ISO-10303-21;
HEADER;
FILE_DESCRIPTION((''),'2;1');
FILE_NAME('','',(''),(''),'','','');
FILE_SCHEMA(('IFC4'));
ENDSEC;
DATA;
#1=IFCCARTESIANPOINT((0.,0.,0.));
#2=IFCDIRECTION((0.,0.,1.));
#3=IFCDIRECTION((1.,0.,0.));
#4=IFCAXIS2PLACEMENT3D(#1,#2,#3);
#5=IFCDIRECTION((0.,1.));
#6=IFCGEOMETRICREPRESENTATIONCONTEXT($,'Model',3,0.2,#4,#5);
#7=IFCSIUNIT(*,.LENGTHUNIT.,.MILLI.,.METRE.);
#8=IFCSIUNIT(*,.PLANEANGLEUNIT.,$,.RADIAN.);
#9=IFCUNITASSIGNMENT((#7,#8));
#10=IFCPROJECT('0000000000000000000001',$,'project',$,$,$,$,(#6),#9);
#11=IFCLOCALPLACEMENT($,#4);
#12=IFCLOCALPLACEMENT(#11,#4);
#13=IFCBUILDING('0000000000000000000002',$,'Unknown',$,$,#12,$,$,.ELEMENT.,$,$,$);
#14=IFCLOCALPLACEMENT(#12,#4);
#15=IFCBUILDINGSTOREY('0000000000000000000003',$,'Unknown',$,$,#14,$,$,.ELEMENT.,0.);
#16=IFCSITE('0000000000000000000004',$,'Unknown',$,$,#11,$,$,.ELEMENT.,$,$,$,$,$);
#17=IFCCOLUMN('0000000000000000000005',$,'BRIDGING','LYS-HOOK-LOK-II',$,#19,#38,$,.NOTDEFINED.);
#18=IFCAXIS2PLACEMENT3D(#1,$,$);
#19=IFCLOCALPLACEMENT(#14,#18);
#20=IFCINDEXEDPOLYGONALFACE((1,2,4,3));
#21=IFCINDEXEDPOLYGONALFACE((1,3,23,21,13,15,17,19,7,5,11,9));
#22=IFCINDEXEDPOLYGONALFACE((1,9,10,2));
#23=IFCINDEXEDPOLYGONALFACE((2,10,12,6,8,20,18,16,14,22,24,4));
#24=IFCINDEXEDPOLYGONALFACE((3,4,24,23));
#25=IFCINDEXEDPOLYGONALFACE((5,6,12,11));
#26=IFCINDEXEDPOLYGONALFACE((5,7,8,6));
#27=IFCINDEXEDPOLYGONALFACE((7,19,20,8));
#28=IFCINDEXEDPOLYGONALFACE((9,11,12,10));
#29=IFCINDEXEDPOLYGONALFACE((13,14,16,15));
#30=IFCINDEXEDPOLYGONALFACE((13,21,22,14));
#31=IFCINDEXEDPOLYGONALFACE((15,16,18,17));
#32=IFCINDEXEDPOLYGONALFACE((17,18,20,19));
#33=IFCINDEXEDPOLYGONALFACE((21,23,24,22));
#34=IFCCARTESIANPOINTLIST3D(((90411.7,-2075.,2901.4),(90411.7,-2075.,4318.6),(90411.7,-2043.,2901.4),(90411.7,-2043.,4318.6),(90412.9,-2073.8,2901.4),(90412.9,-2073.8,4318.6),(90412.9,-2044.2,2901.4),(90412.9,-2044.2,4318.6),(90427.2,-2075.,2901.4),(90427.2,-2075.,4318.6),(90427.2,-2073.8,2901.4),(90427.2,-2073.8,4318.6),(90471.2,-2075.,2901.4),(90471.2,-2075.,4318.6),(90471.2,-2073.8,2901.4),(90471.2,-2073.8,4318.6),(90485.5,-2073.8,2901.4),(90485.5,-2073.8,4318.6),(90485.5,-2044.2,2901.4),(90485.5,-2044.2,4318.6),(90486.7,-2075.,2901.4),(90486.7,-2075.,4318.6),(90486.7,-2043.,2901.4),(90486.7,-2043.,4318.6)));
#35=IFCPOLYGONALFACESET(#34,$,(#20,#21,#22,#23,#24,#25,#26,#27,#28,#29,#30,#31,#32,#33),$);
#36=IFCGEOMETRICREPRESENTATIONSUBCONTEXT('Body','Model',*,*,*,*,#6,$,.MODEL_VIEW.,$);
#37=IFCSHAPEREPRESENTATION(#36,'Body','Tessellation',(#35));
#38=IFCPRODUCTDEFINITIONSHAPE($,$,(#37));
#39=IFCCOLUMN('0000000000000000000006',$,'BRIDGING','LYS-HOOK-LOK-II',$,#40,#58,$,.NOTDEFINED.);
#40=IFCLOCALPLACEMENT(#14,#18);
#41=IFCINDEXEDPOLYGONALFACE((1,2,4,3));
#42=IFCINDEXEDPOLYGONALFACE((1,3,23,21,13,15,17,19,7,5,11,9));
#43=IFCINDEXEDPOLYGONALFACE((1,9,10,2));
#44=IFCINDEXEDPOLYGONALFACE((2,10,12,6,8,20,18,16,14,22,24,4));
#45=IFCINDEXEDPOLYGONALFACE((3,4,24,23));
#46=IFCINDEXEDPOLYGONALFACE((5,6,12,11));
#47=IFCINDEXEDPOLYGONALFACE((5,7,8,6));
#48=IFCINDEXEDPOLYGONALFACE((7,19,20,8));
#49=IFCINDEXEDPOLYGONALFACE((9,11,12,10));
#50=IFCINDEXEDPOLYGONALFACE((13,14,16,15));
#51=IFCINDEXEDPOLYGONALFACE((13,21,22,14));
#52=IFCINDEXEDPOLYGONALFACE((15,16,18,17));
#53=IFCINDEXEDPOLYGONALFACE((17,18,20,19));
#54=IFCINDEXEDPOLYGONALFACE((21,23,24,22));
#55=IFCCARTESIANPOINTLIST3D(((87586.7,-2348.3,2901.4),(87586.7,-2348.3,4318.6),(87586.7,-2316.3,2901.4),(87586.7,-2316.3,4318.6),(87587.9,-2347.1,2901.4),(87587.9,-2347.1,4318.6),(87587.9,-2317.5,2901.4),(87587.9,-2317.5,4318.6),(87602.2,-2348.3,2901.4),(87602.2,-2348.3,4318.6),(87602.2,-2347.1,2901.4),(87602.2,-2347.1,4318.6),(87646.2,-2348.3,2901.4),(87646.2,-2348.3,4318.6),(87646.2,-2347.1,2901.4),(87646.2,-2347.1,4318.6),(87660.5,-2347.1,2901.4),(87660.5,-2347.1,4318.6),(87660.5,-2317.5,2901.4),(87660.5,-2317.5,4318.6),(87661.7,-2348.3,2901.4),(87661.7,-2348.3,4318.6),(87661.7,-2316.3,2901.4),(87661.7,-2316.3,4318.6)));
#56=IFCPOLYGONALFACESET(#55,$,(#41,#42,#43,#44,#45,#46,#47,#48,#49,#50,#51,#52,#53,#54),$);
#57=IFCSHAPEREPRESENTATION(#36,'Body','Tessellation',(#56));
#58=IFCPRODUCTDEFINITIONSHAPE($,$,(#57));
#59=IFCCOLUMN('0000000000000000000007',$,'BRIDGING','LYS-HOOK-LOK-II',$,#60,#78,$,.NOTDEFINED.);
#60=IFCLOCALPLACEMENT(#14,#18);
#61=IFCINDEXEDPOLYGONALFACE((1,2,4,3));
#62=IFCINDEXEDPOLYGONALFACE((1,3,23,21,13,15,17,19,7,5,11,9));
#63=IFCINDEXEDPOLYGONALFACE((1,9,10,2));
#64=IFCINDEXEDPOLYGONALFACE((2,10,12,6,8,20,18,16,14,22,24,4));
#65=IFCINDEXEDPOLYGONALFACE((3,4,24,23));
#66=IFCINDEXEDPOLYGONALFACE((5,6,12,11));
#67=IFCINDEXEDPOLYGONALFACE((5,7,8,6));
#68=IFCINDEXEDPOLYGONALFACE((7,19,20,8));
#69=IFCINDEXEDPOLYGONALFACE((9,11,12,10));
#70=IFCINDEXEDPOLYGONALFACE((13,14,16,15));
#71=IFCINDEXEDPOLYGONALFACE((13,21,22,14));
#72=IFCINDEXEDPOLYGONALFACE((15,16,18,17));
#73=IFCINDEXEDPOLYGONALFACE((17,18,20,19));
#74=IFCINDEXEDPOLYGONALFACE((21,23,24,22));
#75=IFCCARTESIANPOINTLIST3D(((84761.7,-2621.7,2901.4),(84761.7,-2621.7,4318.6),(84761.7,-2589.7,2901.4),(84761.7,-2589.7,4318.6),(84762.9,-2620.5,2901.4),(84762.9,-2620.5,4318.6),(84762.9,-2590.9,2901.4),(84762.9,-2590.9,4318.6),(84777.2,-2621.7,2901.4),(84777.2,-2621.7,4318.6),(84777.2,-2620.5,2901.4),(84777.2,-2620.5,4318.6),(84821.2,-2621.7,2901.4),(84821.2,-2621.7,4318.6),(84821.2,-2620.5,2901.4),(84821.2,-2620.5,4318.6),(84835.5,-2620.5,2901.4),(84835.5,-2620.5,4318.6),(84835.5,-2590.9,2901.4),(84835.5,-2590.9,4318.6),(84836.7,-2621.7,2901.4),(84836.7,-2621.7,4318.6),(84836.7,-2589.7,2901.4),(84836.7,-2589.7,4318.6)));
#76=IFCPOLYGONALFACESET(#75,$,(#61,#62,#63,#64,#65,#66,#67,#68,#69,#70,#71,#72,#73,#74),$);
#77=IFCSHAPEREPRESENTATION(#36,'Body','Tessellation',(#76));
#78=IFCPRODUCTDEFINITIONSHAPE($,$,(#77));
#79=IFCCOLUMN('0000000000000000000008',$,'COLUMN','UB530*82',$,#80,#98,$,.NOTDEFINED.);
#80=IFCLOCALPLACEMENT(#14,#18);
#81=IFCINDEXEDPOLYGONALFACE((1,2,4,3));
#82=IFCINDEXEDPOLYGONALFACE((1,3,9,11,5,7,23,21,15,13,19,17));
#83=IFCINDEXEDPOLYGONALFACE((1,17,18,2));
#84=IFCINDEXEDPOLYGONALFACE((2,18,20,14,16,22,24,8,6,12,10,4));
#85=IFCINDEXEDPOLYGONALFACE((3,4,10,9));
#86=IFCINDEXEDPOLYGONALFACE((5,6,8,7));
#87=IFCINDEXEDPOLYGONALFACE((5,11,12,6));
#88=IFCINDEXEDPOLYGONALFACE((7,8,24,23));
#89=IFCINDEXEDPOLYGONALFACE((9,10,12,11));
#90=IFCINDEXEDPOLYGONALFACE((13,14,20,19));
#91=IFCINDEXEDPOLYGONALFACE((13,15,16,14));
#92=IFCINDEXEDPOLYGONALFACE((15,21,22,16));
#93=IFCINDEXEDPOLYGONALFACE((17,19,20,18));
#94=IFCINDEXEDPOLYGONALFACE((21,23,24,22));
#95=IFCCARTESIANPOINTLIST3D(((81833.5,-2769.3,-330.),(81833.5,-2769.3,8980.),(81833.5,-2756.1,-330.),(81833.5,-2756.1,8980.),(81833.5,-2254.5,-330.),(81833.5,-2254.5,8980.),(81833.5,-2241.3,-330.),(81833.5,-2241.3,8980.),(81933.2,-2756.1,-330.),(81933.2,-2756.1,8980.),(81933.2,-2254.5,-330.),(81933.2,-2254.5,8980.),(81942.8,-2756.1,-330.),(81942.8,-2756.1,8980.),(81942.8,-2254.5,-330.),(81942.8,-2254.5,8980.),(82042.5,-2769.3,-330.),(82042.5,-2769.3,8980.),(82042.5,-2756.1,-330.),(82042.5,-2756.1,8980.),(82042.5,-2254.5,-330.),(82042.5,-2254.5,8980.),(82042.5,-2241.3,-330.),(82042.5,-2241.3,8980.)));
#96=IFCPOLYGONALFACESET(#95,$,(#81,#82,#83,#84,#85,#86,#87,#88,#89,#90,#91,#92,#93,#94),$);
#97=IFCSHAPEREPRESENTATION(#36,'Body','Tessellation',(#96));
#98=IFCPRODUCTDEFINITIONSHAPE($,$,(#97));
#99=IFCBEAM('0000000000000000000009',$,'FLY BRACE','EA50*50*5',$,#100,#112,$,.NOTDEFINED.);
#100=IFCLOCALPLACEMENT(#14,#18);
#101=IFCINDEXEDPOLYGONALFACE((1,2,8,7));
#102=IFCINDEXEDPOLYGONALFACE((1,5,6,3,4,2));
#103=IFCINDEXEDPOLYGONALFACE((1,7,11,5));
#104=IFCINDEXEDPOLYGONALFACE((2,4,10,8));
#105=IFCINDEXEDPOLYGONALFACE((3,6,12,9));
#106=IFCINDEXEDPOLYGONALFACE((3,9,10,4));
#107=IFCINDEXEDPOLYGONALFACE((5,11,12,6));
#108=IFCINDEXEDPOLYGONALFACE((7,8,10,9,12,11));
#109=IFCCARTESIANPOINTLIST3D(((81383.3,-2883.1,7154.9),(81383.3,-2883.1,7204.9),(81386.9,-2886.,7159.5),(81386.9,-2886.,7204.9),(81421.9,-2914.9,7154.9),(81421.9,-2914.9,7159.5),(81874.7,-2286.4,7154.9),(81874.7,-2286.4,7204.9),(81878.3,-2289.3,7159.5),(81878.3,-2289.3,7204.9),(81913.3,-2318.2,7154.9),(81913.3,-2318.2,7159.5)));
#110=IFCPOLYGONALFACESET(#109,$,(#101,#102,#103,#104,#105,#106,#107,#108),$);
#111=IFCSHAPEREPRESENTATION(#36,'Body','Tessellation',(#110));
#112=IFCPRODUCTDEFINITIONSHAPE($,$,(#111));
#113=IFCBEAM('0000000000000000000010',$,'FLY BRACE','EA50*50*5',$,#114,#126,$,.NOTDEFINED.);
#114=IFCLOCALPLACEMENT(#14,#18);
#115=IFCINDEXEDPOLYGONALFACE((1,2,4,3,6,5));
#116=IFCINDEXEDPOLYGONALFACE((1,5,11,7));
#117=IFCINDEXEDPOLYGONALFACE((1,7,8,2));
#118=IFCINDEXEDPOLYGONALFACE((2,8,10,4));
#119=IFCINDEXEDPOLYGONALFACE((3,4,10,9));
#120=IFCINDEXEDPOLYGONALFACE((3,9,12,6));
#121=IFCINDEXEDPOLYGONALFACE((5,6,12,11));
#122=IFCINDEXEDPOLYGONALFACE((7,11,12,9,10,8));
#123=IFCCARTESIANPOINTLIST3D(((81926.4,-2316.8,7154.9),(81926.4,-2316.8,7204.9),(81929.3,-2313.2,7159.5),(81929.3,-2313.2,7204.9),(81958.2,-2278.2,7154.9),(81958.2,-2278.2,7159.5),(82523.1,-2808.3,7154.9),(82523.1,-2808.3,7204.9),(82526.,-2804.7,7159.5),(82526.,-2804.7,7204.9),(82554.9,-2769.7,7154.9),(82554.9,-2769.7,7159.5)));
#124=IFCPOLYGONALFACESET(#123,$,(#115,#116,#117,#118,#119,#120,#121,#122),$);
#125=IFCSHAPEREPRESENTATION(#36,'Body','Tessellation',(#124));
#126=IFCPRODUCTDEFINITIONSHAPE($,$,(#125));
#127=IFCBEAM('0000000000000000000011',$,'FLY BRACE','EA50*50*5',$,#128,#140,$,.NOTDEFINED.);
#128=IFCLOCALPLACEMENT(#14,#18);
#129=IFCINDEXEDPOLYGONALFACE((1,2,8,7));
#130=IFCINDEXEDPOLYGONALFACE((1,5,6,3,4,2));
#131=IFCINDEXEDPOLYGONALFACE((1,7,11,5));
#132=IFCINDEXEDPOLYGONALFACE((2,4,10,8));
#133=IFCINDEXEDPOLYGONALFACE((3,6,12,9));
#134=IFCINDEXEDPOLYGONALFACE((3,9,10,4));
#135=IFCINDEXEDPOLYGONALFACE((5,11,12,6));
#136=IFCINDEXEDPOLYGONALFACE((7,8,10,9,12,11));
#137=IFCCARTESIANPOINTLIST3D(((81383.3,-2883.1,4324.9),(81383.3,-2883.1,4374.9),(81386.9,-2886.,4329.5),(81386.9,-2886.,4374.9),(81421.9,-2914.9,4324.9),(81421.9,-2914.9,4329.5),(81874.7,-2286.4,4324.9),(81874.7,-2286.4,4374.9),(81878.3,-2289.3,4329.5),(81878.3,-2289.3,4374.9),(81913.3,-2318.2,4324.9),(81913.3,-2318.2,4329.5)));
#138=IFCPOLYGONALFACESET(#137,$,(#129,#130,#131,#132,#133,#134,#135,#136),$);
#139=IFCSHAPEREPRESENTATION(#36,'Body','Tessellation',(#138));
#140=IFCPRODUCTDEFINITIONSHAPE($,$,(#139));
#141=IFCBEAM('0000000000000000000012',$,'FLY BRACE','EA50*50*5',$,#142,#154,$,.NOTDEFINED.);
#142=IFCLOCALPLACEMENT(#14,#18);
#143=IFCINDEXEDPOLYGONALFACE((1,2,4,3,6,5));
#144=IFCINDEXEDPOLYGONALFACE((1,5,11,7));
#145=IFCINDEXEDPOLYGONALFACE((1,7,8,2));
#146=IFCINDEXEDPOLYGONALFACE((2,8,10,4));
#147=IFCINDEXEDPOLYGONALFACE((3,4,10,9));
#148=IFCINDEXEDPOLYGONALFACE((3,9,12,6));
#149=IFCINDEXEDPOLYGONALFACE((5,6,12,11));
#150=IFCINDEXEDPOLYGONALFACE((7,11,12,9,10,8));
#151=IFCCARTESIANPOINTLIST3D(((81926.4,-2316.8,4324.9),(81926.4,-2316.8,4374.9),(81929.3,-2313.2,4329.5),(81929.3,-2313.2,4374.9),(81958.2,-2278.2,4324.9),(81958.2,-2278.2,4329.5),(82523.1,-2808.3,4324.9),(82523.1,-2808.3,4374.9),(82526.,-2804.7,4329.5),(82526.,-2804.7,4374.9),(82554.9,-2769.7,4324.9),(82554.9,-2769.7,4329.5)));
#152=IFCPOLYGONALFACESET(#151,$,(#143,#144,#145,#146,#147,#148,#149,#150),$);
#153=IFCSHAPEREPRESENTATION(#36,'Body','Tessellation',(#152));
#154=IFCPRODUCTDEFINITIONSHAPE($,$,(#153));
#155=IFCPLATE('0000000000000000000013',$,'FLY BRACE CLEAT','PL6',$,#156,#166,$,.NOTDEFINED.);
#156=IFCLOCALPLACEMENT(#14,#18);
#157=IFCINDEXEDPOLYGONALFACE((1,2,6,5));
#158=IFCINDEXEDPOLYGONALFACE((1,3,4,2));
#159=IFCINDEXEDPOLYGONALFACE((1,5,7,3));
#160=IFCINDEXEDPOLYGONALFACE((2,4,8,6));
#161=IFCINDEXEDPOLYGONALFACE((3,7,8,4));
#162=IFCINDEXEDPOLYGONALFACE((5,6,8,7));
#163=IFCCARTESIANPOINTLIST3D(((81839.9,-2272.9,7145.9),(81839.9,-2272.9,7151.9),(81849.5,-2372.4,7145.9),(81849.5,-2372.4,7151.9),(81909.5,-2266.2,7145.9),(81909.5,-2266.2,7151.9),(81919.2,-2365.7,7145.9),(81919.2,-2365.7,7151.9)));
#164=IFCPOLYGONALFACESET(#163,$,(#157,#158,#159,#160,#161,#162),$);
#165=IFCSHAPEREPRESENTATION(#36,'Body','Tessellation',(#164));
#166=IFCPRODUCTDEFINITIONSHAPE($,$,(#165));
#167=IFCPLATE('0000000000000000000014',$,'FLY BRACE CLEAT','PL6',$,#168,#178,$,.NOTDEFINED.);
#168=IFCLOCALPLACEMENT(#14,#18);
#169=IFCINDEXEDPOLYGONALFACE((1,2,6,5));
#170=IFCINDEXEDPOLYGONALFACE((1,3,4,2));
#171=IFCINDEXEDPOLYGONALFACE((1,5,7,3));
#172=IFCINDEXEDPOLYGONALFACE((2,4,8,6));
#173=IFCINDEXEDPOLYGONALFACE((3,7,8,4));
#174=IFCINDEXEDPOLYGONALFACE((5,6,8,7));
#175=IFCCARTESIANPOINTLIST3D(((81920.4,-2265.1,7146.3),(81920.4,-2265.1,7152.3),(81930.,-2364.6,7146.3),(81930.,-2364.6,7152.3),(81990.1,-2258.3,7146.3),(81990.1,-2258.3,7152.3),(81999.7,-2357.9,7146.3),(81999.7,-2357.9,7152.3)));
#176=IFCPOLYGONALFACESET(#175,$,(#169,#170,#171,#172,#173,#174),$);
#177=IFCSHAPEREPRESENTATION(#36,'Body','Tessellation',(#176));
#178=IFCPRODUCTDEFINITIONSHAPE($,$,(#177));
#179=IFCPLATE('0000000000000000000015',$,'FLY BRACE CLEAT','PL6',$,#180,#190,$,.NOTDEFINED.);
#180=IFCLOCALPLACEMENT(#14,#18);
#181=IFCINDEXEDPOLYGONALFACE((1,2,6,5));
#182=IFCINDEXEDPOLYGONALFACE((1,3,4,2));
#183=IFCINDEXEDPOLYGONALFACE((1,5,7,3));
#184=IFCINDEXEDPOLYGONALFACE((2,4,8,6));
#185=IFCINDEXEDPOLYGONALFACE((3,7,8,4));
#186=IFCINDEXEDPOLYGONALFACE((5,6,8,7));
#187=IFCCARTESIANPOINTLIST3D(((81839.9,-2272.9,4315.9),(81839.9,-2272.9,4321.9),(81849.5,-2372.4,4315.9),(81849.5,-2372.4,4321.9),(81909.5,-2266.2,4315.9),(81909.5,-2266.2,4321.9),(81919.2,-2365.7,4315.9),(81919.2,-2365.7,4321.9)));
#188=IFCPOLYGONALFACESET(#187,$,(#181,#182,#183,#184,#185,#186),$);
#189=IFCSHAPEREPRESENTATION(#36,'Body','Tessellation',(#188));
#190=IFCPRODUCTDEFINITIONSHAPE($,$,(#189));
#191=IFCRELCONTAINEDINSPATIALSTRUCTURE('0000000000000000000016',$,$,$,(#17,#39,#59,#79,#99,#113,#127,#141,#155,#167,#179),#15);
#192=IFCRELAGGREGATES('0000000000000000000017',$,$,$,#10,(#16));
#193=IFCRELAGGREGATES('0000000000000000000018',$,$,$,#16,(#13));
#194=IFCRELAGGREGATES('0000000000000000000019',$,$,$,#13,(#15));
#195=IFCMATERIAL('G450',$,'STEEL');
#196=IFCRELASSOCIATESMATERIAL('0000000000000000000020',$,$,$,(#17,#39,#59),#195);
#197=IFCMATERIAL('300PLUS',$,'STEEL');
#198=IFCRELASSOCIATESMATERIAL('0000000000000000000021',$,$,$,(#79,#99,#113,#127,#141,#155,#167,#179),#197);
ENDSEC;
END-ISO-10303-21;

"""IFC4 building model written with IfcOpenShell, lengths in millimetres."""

from ifc_helpers import new_model, si_unit, direction, frame, origin_with_axes, place, context, subcontext, project, spatial, line, indexed_curve, outline, extrude, material, element, save


model = new_model("IFC4")

# Units and contexts
model_context = context("Model", 3, precision=0.2, world=origin_with_axes(), true_north=direction((0.0, 1.0)))
body_context = subcontext(model_context, "Body", "Model", "MODEL_VIEW")
ifc_project = project(units=[si_unit("LENGTHUNIT", "METRE", prefix="MILLI"), si_unit("PLANEANGLEUNIT", "RADIAN")], contexts=[model_context])

# Site, building, storey
site_placement = place(None, origin_with_axes())
site = spatial("IfcSite", under=ifc_project, at=site_placement, Name="Unknown", CompositionType="ELEMENT")
building_placement = place(site_placement, origin_with_axes())
building = spatial("IfcBuilding", under=site, at=building_placement, Name="Unknown", CompositionType="ELEMENT")
storey_placement = place(building_placement, origin_with_axes())
storey = spatial("IfcBuildingStorey", under=building, at=storey_placement, Name="Unknown", CompositionType="ELEMENT", Elevation=0.0)

# Columns
ifc_material_1 = material(Name="G450", Category="STEEL")
for number, where, z_axis, x_axis, name in (
    (1, (90449.2, -2059.0, 2901.4), (0.0, -1.0, 0.0), (0.0, 0.0, 1.0), "BRIDGING"),
    (2, (87624.2, -2332.3, 2901.4), (0.0, -1.0, 0.0), (0.0, 0.0, 1.0), "BRIDGING"),
    (3, (84799.2, -2605.7, 2901.4), (0.0, -1.0, 0.0), (0.0, 0.0, 1.0), "BRIDGING"),
):
    element("IfcColumn", number, at=place(storey_placement, frame(where, z_axis=z_axis, x_axis=x_axis)), inside=storey, material=ifc_material_1, Name=name, Description="LYS-HOOK-LOK-II", PredefinedType="NOTDEFINED", context=body_context, shape_type="SolidModel", body=[
        extrude(outline(indexed_curve([(16.0, -37.5), (16.0, -22.0), (14.8, -22.0), (14.8, -36.3), (-14.8, -36.3), (-14.8, 36.3), (14.8, 36.3), (14.8, 22.0), (16.0, 22.0), (16.0, 37.5), (-16.0, 37.5), (-16.0, -37.5)], segments=[line(1, 2, 3, 4, 5, 6, 7, 8, 9, 10, 11, 12, 1)])), frame((0.0, 0.0, 0.0), z_axis=(-1.0, 0.0, 0.0), x_axis=(0.0, 0.0, 1.0)), (0.0, 0.0, -1.0), 1417.2),
    ])
ifc_material_2 = material(Name="300PLUS", Category="STEEL")
column_placement = place(storey_placement, frame((81938.0, -2505.3, -330.0), z_axis=(-1.0, 0.0, 0.0), x_axis=(0.0, 0.0, 1.0)))
element("IfcColumn", 4, at=column_placement, inside=storey, material=ifc_material_2, Name="COLUMN", Description="UB530*82", PredefinedType="NOTDEFINED", context=body_context, shape_type="SolidModel", body=[
    extrude(outline(indexed_curve([(-104.5, -264.0), (104.5, -264.0), (104.5, -250.8), (4.8, -250.8), (4.8, 250.8), (104.5, 250.8), (104.5, 264.0), (-104.5, 264.0), (-104.5, 250.8), (-4.8, 250.8), (-4.8, -250.8), (-104.5, -250.8)], segments=[line(1, 2, 3, 4, 5, 6, 7, 8, 9, 10, 11, 12, 1)])), frame((0.0, 0.0, 0.0), z_axis=(-1.0, 0.0, 0.0), x_axis=(0.0, 0.0, 1.0)), (0.0, 0.0, -1.0), 9310.0),
])

# Beams
beam_1_placement = place(storey_placement, frame((81894.0, -2302.3, 7179.9), z_axis=(0.0, 0.0, 1.0), x_axis=(-0.635707, -0.77193, 0.0)))
element("IfcBeam", 5, at=beam_1_placement, inside=storey, material=ifc_material_2, Name="FLY BRACE", Description="EA50*50*5", PredefinedType="NOTDEFINED", context=body_context, shape_type="SolidModel", body=[
    extrude(outline(indexed_curve([(-25.0, -25.0), (25.0, -25.0), (25.0, -20.4), (-20.4, -20.4), (-20.4, 25.0), (-25.0, 25.0)], segments=[line(1, 2, 3, 4, 5, 6, 1)])), frame((0.0, 0.0, 0.0), z_axis=(-1.0, 0.0, 0.0), x_axis=(0.0, 0.0, 1.0)), (0.0, 0.0, -1.0), 773.0),
])
beam_2_placement = place(storey_placement, frame((81942.3, -2297.5, 7179.9), z_axis=(0.0, 0.0, 1.0), x_axis=(0.771867, -0.635784, 0.0)))
element("IfcBeam", 6, at=beam_2_placement, inside=storey, material=ifc_material_2, Name="FLY BRACE", Description="EA50*50*5", PredefinedType="NOTDEFINED", context=body_context, shape_type="SolidModel", body=[
    extrude(outline(indexed_curve([(-25.0, -25.0), (25.0, -25.0), (25.0, -20.4), (-20.4, -20.4), (-20.4, 25.0), (-25.0, 25.0)], segments=[line(1, 2, 3, 4, 5, 6, 1)])), frame((0.0, 0.0, 0.0), z_axis=(-1.0, 0.0, 0.0), x_axis=(0.0, 0.0, 1.0)), (0.0, 0.0, -1.0), 773.1),
])
beam_3_placement = place(storey_placement, frame((81894.0, -2302.3, 4349.9), z_axis=(0.0, 0.0, 1.0), x_axis=(-0.635707, -0.77193, 0.0)))
element("IfcBeam", 7, at=beam_3_placement, inside=storey, material=ifc_material_2, Name="FLY BRACE", Description="EA50*50*5", PredefinedType="NOTDEFINED", context=body_context, shape_type="SolidModel", body=[
    extrude(outline(indexed_curve([(-25.0, -25.0), (25.0, -25.0), (25.0, -20.4), (-20.4, -20.4), (-20.4, 25.0), (-25.0, 25.0)], segments=[line(1, 2, 3, 4, 5, 6, 1)])), frame((0.0, 0.0, 0.0), z_axis=(-1.0, 0.0, 0.0), x_axis=(0.0, 0.0, 1.0)), (0.0, 0.0, -1.0), 773.0),
])
beam_4_placement = place(storey_placement, frame((81942.3, -2297.5, 4349.9), z_axis=(0.0, 0.0, 1.0), x_axis=(0.771867, -0.635784, 0.0)))
element("IfcBeam", 8, at=beam_4_placement, inside=storey, material=ifc_material_2, Name="FLY BRACE", Description="EA50*50*5", PredefinedType="NOTDEFINED", context=body_context, shape_type="SolidModel", body=[
    extrude(outline(indexed_curve([(-25.0, -25.0), (25.0, -25.0), (25.0, -20.4), (-20.4, -20.4), (-20.4, 25.0), (-25.0, 25.0)], segments=[line(1, 2, 3, 4, 5, 6, 1)])), frame((0.0, 0.0, 0.0), z_axis=(-1.0, 0.0, 0.0), x_axis=(0.0, 0.0, 1.0)), (0.0, 0.0, -1.0), 773.1),
])

# Plates
plate_1_placement = place(storey_placement, frame((81909.5, -2266.2, 7148.9), z_axis=(0.0, 0.0, 1.0), x_axis=(-0.995399, -0.095821, 0.0)))
element("IfcPlate", 9, at=plate_1_placement, inside=storey, material=ifc_material_2, Name="FLY BRACE CLEAT", Description="PL6", PredefinedType="NOTDEFINED", context=body_context, shape_type="SolidModel", body=[
    extrude(outline(indexed_curve([(0.0, 0.0), (69.9, 0.0), (69.9, 100.0), (-0.1, 100.0)], segments=[line(1, 2, 3, 4, 1)])), frame((0.0, 0.0, 3.0), z_axis=(0.0, 0.0, 1.0), x_axis=(1.0, 0.0, 0.0)), (0.0, 0.0, -1.0), 6.0),
])
plate_2_placement = place(storey_placement, frame((81930.0, -2364.6, 7149.3), z_axis=(0.0, 0.0, 1.0), x_axis=(0.995412, 0.095685, 0.0)))
element("IfcPlate", 10, at=plate_2_placement, inside=storey, material=ifc_material_2, Name="FLY BRACE CLEAT", Description="PL6", PredefinedType="NOTDEFINED", context=body_context, shape_type="SolidModel", body=[
    extrude(outline(indexed_curve([(0.0, 0.0), (70.0, 0.0), (70.0, 100.1), (0.0, 100.0)], segments=[line(1, 2, 3, 4, 1)])), frame((0.0, 0.0, 3.0), z_axis=(0.0, 0.0, 1.0), x_axis=(1.0, 0.0, 0.0)), (0.0, 0.0, -1.0), 6.0),
])
plate_3_placement = place(storey_placement, frame((81909.5, -2266.2, 4318.9), z_axis=(0.0, 0.0, 1.0), x_axis=(-0.995399, -0.095821, 0.0)))
element("IfcPlate", 11, at=plate_3_placement, inside=storey, material=ifc_material_2, Name="FLY BRACE CLEAT", Description="PL6", PredefinedType="NOTDEFINED", context=body_context, shape_type="SolidModel", body=[
    extrude(outline(indexed_curve([(0.0, 0.0), (69.9, 0.0), (69.9, 100.0), (-0.1, 100.0)], segments=[line(1, 2, 3, 4, 1)])), frame((0.0, 0.0, 3.0), z_axis=(0.0, 0.0, 1.0), x_axis=(1.0, 0.0, 0.0)), (0.0, 0.0, -1.0), 6.0),
])

save(model, "model.ifc")
